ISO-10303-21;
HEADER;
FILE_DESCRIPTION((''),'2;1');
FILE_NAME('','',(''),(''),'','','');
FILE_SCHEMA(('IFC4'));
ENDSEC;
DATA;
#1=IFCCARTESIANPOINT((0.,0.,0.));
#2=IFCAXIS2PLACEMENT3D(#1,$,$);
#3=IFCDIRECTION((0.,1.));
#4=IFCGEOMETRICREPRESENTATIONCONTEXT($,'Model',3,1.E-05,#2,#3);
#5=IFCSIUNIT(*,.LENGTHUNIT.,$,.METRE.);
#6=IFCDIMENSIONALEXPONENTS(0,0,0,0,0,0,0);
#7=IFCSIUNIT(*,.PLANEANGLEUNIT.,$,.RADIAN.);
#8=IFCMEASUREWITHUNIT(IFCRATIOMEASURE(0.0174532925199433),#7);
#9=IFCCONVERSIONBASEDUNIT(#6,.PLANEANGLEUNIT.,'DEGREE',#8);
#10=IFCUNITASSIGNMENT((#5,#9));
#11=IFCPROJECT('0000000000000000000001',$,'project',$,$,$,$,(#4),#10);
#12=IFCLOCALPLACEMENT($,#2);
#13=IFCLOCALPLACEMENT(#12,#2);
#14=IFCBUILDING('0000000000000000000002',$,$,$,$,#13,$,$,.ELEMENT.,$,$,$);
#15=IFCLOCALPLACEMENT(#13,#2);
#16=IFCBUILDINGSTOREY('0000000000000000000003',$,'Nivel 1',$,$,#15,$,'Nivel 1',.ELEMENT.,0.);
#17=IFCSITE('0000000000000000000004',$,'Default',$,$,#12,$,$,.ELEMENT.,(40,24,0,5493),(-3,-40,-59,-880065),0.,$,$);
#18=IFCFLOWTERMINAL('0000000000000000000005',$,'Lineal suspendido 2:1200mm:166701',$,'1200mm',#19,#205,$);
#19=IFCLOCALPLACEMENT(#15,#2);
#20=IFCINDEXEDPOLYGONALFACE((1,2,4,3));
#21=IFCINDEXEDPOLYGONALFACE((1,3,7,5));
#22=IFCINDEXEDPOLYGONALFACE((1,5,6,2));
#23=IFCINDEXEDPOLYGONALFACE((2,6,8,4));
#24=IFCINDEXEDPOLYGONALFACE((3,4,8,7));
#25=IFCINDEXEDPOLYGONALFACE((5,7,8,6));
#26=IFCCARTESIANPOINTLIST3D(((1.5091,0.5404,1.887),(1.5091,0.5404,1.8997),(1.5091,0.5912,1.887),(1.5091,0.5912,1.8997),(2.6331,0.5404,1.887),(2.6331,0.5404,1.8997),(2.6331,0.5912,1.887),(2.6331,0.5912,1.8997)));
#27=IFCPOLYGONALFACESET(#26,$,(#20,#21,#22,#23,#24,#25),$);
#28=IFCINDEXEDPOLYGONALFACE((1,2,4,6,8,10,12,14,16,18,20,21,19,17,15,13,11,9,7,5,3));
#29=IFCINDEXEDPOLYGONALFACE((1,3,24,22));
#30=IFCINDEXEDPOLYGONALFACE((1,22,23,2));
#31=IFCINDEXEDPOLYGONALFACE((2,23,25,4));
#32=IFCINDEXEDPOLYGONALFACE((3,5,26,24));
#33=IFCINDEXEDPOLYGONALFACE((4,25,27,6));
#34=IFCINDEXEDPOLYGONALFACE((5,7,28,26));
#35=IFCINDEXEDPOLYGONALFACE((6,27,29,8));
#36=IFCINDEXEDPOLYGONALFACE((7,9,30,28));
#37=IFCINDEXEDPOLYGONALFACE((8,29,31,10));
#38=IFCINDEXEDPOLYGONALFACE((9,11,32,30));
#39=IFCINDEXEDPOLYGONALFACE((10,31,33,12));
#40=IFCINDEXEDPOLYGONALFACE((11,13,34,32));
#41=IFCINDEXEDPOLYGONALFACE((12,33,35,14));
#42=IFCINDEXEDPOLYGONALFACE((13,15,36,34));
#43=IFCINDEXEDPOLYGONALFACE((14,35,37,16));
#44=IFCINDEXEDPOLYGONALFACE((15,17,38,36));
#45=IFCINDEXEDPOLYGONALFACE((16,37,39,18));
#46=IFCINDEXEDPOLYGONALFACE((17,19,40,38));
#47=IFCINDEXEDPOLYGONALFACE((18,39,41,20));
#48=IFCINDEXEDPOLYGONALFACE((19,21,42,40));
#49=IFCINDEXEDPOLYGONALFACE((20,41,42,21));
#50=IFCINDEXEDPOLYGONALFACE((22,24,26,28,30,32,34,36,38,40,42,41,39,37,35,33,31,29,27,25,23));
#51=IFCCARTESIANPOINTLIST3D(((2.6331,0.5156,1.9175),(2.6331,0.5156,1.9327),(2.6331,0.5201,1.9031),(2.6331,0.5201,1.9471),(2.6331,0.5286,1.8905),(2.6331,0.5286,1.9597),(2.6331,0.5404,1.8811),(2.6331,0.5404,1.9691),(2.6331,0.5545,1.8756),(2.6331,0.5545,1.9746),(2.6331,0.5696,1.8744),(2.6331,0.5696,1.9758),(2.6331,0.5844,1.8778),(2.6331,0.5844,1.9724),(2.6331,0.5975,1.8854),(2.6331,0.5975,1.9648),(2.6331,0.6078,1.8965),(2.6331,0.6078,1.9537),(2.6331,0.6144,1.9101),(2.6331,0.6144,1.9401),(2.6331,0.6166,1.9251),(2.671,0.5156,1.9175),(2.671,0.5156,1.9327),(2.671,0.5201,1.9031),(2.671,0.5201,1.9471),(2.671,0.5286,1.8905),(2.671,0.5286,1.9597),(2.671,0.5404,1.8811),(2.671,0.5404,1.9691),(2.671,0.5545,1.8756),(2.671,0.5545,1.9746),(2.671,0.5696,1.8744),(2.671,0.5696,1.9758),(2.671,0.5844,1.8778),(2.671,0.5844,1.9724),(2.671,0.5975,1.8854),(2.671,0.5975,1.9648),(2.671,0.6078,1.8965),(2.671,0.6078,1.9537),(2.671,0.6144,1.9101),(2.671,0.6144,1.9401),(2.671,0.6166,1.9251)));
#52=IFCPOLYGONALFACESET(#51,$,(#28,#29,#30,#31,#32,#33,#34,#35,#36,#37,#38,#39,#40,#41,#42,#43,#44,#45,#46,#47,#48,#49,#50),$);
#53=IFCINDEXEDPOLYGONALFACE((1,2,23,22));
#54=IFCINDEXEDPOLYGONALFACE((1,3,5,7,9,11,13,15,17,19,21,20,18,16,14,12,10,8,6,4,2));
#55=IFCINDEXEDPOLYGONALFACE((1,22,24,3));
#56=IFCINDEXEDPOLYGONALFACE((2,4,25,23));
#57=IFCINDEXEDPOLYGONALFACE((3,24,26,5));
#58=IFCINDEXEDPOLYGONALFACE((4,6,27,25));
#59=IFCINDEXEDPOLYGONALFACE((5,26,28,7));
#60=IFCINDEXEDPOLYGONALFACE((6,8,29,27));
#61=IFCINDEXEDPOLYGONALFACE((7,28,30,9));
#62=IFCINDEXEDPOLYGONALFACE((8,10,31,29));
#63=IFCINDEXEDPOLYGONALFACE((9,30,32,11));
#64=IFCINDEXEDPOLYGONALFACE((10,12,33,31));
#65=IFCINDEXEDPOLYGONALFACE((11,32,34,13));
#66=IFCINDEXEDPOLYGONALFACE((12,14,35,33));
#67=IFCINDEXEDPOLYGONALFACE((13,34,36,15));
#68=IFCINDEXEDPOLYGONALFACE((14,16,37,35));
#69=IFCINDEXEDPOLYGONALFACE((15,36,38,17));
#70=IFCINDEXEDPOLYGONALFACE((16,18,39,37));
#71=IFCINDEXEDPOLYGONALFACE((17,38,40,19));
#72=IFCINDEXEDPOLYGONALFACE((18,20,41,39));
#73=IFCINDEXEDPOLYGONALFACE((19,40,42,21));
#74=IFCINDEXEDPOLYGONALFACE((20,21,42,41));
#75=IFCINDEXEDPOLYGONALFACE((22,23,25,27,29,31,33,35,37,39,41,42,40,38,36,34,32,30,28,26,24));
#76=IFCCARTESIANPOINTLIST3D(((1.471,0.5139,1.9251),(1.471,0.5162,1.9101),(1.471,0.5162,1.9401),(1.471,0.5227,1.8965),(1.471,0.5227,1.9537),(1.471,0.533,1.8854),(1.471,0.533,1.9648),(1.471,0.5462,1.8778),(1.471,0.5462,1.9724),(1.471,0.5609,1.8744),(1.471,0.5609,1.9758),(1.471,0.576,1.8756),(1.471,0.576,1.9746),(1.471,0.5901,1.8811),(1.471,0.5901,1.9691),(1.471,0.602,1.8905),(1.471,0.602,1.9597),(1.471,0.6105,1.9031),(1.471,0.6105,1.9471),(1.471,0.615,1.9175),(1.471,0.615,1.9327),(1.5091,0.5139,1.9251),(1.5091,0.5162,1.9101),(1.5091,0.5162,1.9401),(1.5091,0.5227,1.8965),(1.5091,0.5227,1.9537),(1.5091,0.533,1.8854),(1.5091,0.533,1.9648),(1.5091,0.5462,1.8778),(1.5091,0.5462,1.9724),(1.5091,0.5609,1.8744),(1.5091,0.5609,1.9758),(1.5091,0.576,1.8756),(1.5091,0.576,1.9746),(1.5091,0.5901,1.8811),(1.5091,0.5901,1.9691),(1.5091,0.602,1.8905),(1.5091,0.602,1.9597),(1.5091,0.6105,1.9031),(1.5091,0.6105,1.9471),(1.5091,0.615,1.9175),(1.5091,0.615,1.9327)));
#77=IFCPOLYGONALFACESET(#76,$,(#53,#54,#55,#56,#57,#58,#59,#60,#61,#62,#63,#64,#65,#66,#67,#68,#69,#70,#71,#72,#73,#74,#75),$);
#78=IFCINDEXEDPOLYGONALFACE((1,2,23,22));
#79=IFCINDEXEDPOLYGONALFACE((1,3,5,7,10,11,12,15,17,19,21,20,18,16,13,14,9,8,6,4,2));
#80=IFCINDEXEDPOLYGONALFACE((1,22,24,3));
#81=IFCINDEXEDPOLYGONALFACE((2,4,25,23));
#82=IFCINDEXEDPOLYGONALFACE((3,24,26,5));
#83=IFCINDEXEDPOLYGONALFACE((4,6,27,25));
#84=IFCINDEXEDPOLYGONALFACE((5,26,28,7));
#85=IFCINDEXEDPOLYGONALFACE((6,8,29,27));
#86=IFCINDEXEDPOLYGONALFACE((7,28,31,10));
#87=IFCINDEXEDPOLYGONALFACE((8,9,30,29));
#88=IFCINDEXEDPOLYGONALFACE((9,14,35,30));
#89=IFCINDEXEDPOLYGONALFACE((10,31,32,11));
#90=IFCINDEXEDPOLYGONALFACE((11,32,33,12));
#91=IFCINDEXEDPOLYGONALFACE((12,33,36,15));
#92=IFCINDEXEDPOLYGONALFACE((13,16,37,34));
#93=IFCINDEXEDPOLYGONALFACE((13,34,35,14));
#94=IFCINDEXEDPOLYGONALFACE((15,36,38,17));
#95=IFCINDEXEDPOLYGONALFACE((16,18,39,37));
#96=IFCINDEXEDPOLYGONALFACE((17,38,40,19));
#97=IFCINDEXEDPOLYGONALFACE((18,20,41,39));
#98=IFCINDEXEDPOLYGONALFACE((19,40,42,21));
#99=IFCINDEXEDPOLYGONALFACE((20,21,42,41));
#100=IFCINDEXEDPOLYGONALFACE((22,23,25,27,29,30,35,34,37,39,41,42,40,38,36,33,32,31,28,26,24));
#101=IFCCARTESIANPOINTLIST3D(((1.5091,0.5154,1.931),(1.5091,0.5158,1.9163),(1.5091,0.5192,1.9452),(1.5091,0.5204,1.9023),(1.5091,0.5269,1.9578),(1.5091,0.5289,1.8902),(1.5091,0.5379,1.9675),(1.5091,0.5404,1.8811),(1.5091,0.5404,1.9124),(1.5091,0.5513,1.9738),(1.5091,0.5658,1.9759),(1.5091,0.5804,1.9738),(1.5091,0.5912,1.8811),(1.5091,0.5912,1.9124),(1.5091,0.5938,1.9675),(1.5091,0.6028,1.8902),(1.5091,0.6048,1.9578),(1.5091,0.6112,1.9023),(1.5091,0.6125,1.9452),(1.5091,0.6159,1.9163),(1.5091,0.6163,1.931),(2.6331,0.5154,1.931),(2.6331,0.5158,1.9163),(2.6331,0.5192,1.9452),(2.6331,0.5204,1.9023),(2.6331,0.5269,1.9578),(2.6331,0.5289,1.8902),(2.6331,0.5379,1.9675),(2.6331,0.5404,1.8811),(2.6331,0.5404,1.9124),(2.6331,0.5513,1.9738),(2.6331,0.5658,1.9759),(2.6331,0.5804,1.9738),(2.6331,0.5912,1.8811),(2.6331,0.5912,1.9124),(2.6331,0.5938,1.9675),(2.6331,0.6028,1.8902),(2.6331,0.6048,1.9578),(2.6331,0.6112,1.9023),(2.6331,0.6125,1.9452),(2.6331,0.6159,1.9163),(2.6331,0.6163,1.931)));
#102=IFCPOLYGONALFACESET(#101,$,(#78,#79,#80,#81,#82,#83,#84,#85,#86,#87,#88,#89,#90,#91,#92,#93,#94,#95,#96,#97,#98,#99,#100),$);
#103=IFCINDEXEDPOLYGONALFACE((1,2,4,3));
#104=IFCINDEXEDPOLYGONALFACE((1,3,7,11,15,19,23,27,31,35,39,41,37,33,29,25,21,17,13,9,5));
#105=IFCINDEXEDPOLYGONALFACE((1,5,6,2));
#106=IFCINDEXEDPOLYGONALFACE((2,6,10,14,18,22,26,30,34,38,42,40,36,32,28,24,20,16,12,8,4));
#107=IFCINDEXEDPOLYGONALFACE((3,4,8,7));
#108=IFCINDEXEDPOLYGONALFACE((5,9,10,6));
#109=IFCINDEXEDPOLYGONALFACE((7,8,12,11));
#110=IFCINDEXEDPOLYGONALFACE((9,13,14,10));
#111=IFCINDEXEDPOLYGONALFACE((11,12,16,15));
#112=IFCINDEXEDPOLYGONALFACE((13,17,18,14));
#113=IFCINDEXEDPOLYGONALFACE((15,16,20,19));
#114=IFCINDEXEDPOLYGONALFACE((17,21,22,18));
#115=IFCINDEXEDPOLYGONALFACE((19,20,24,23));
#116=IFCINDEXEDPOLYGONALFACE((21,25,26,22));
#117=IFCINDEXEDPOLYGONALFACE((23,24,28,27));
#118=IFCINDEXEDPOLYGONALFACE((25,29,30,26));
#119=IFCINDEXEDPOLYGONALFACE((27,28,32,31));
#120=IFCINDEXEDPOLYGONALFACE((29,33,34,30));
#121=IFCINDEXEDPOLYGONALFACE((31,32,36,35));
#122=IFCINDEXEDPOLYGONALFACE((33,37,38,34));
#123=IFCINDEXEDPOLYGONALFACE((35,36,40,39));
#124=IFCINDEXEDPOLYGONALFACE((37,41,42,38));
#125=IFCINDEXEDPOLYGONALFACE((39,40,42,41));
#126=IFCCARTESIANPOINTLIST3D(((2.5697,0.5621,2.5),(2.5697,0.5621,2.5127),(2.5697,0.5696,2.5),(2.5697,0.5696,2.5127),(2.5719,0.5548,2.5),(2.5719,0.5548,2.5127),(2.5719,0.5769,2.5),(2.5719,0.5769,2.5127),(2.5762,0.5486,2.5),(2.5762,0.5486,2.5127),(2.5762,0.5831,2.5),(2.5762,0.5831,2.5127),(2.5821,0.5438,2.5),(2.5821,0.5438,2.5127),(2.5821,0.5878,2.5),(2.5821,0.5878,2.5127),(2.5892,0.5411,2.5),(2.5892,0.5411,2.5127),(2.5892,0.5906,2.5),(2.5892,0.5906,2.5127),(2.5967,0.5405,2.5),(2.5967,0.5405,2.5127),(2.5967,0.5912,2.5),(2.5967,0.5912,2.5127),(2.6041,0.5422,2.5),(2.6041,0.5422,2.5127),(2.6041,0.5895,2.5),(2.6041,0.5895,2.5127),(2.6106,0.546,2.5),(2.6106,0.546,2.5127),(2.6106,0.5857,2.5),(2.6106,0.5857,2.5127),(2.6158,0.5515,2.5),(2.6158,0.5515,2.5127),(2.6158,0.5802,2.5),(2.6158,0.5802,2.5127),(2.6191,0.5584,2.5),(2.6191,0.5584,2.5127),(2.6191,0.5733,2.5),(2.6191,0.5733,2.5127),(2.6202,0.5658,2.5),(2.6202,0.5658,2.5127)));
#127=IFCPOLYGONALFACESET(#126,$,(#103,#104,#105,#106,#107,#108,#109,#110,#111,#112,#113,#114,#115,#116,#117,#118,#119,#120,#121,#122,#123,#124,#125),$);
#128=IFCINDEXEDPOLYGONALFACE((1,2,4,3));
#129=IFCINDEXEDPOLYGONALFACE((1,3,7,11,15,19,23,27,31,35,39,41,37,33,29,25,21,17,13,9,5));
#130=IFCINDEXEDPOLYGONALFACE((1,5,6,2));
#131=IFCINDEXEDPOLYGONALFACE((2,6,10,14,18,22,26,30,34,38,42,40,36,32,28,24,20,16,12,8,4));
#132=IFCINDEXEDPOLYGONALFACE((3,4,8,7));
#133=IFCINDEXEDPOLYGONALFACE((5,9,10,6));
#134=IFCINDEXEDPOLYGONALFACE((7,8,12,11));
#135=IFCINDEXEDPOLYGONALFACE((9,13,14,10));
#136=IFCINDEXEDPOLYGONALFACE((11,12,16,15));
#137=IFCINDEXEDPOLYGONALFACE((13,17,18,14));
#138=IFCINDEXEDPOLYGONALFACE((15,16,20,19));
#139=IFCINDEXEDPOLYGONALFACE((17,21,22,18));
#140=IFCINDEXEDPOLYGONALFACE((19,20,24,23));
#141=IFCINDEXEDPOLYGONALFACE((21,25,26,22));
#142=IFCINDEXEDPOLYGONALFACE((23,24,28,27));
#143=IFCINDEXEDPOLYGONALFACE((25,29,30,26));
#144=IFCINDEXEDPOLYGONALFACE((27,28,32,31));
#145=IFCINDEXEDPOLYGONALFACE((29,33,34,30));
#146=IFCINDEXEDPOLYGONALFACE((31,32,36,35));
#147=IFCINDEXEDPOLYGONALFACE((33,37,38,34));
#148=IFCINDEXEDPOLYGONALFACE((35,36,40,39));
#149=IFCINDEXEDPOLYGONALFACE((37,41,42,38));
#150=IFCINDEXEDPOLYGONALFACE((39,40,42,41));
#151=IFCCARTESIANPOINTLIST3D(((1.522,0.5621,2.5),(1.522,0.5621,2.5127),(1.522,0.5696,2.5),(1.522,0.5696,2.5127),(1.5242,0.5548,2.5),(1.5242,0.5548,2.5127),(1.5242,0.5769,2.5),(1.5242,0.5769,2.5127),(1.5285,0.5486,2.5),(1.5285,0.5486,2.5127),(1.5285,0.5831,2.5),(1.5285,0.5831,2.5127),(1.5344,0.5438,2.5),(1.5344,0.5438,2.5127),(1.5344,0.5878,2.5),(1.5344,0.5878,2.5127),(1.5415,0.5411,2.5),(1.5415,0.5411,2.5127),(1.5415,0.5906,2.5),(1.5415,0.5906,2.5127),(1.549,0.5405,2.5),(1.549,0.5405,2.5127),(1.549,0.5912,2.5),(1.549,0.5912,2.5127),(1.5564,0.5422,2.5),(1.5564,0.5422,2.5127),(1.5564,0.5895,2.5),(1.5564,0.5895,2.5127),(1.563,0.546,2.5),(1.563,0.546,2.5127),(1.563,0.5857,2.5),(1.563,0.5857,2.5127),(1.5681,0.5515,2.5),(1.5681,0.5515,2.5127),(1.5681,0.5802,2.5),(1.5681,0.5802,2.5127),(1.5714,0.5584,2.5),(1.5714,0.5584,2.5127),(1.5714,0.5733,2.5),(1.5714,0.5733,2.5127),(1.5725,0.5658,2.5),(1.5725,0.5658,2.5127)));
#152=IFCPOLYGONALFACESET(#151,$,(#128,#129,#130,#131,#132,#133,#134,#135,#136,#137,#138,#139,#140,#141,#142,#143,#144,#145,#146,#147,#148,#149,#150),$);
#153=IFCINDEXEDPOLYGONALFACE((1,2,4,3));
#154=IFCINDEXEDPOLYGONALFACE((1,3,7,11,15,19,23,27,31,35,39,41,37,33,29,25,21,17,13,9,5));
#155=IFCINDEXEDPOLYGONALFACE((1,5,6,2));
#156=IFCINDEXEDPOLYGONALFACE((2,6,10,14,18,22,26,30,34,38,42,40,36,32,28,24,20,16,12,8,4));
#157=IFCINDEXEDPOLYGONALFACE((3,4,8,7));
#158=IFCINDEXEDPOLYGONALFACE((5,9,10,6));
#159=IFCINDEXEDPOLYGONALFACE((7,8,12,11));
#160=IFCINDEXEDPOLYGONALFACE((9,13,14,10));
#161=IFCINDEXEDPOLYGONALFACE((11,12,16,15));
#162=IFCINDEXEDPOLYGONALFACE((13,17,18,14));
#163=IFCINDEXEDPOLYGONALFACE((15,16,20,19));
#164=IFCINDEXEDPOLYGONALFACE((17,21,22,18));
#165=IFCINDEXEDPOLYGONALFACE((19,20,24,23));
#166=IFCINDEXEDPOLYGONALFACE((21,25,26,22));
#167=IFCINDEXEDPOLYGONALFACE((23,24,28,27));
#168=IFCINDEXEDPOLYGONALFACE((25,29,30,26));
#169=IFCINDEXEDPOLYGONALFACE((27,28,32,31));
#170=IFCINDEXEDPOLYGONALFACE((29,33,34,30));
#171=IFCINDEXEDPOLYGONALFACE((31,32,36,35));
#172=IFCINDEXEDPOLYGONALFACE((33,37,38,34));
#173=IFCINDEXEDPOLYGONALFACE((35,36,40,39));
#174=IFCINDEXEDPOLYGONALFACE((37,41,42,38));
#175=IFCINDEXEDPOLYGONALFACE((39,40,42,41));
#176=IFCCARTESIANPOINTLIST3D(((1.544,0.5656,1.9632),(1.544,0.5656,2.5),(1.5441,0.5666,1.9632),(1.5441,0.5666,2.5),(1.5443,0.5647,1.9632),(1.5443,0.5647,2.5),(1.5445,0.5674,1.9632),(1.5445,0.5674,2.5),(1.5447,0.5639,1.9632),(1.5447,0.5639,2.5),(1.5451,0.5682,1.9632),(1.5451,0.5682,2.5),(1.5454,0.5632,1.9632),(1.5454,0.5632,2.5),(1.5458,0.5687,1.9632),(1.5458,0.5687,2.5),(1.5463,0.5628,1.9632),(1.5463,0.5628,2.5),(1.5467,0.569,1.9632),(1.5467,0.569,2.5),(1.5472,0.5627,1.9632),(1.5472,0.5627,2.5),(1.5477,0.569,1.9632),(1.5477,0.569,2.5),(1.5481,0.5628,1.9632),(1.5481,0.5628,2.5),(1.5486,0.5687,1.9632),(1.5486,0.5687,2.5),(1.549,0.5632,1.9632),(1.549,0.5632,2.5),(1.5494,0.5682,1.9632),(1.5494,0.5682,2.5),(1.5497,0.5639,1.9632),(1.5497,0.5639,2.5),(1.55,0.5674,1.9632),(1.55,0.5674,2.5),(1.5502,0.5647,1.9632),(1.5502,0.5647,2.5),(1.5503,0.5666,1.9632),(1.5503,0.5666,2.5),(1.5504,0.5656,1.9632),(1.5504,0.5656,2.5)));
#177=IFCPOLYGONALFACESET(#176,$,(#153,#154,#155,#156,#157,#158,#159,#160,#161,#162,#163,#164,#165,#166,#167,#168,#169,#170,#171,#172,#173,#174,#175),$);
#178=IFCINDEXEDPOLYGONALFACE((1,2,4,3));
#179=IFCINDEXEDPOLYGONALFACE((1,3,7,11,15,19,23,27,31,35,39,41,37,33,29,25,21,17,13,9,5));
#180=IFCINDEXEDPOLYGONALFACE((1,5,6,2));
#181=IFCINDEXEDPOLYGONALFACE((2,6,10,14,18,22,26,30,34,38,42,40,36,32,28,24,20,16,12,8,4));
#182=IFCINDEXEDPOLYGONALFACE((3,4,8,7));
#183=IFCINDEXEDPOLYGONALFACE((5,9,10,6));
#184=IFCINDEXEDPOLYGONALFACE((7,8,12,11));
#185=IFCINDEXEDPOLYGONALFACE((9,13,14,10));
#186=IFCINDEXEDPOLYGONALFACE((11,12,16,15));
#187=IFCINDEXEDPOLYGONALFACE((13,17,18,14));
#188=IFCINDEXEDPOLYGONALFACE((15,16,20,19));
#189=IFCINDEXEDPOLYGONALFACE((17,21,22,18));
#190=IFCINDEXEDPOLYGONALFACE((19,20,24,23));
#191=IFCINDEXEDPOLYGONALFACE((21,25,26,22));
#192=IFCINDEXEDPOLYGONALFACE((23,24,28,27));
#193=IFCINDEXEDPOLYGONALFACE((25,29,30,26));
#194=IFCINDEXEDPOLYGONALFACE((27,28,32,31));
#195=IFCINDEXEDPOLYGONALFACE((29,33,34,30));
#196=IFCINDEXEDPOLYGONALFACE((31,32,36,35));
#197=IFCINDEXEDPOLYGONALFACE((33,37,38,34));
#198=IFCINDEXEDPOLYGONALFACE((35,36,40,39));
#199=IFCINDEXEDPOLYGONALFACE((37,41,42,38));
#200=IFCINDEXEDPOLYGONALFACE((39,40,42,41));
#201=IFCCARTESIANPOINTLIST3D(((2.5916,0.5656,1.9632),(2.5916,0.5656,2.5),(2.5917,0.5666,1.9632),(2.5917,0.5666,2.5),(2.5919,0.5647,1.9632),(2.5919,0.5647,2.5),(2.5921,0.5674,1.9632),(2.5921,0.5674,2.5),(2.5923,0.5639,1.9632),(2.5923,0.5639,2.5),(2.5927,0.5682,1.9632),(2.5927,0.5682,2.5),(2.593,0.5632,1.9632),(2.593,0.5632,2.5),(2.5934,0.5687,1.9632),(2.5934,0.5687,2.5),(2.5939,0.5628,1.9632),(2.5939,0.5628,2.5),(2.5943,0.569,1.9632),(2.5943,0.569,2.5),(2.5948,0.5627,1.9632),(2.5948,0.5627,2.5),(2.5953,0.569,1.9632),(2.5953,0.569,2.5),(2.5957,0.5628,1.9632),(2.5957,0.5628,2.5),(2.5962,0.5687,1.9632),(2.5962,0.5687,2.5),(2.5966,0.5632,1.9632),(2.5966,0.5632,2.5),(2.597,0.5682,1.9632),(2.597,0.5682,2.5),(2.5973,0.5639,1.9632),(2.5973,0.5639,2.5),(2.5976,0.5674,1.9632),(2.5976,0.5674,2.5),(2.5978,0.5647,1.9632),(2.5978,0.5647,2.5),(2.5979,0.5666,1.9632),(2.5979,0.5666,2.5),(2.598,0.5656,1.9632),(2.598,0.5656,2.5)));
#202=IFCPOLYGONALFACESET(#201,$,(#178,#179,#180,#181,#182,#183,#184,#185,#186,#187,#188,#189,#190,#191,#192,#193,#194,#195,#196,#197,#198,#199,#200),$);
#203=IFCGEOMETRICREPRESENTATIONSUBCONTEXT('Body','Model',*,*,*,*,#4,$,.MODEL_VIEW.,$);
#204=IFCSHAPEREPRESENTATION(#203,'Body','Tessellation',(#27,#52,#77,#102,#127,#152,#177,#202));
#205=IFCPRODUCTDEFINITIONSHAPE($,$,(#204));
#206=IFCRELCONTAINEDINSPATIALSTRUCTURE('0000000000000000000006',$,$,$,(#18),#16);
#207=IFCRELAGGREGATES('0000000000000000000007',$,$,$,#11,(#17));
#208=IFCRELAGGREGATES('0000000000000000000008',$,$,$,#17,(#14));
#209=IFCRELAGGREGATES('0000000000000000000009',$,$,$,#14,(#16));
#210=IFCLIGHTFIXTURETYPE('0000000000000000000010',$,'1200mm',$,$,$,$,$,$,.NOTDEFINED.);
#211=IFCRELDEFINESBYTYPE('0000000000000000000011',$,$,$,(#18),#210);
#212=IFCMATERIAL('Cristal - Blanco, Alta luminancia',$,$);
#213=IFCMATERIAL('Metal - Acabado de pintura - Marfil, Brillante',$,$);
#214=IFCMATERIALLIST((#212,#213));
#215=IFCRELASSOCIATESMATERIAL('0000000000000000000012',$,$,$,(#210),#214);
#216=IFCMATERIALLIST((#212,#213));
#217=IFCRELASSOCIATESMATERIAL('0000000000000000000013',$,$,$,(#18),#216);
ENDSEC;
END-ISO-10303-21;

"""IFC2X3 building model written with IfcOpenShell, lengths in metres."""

from ifc_helpers import new_model, entity, si_unit, converted_unit, direction, frame, frame_2d, origin, origin_2d_with_axis, place, context, subcontext, project, spatial, polyline, circle_curve, parameter, trimmed, segment, composite_curve, rectangle, circle, outline, extrude, source, transform, mapped, material, material_list, type_object, type_shapes, element, save


model = new_model("IFC2X3")

# Units and contexts
model_context = context("Model", 3, precision=1e-05, world=origin(), true_north=direction((0.0, 1.0)))
body_context = subcontext(model_context, "Body", "Model", "MODEL_VIEW")
ifc_project = project(units=[si_unit("LENGTHUNIT", "METRE"), converted_unit("PLANEANGLEUNIT", "DEGREE", entity("IfcRatioMeasure", 0.0174532925199433), si_unit("PLANEANGLEUNIT", "RADIAN"), dimensions=[0, 0, 0, 0, 0, 0, 0])], contexts=[model_context])

# Site, building, storey
site_placement = place(None, origin())
site = spatial("IfcSite", under=ifc_project, at=site_placement, Name="Default", CompositionType="ELEMENT", RefLatitude=(40, 24, 0, 5493), RefLongitude=(-3, -40, -59, -880065), RefElevation=0.0)
building_placement = place(site_placement, origin())
building = spatial("IfcBuilding", under=site, at=building_placement, CompositionType="ELEMENT")
storey_placement = place(building_placement, origin())
storey = spatial("IfcBuildingStorey", under=building, at=storey_placement, Name="Nivel 1", LongName="Nivel 1", CompositionType="ELEMENT", Elevation=0.0)

# Flow terminal
ifc_material_1 = material(Name="Cristal - Blanco, Alta luminancia")
ifc_material_2 = material(Name="Metal - Acabado de pintura - Marfil, Brillante")
ifc_material_list_1 = material_list([ifc_material_1, ifc_material_2])
light_fixture_type = type_object("IfcLightFixtureType", Name="1200mm", PredefinedType="NOTDEFINED", material=ifc_material_list_1)
shared_shape = source(origin(), body_context, "Body", "SweptSolid", [
    extrude(rectangle(XDim=1.124, YDim=0.0508, at=origin_2d_with_axis()), frame((0.0001, 0.0, 1.8127), z_axis=(0.0, 0.0, 1.0), x_axis=(-1.0, 0.0, 0.0)), (0.0, 0.0, 1.0), 0.0127),
    extrude(circle(Radius=0.0508, at=frame_2d((0.0, 0.0), x_axis=(1.0, 0.0))), frame((0.5621, 0.0, 1.8508), z_axis=(1.0, 0.0, 0.0), x_axis=(0.0, 1.0, 0.0)), (0.0, 0.0, 1.0), 0.0379),
    extrude(circle(Radius=0.0508, at=frame_2d((0.0, 0.0), x_axis=(1.0, 0.0))), frame((-0.6, -0.0011, 1.8508), z_axis=(1.0, 0.0, 0.0), x_axis=(0.0, -1.0, 0.0)), (0.0, 0.0, 1.0), 0.0381),
    extrude(outline(composite_curve([segment(trimmed(circle_curve(frame_2d((0.0125, 0.0), x_axis=(0.0, 1.0)), 0.0508), [parameter(120.0)], [parameter(270.0)], True, "PARAMETER"), True, "CONTINUOUS"), segment(trimmed(circle_curve(frame_2d((0.0125, 0.0), x_axis=(0.0, 1.0)), 0.0508), [parameter(270.0)], [parameter(60.0)], True, "PARAMETER"), True, "CONTINUOUS"), segment(polyline([(-0.0315, 0.0254), (-0.0002, 0.0254)]), True, "CONTINUOUS"), segment(polyline([(-0.0002, 0.0254), (-0.0002, -0.0254)]), True, "CONTINUOUS"), segment(polyline([(-0.0002, -0.0254), (-0.0315, -0.0254)]), True, "CONTINUOUS")], self_intersect=False)), frame((-0.5619, 0.0, 1.8383), z_axis=(-1.0, 0.0, 0.0), x_axis=(0.0, 0.0, 1.0)), (0.0, 0.0, -1.0), 1.124),
    extrude(circle(Radius=0.0254, at=frame_2d((0.0, 0.0), x_axis=(1.0, 0.0))), frame((0.5238, 0.0, 2.4257)), (0.0, 0.0, 1.0), 0.0127),
    extrude(circle(Radius=0.0254, at=frame_2d((0.0, 0.0), x_axis=(1.0, 0.0))), frame((-0.5239, 0.0, 2.4257)), (0.0, 0.0, 1.0), 0.0127),
    extrude(circle(Radius=0.0032, at=frame_2d((0.0, 0.0), x_axis=(1.0, 0.0))), frame((-0.5238, 0.0, 1.8889), z_axis=(0.0, 0.0, 1.0), x_axis=(0.0, -1.0, 0.0)), (0.0, 0.0, 1.0), 0.5368),
    extrude(circle(Radius=0.0032, at=frame_2d((0.0, 0.0), x_axis=(1.0, 0.0))), frame((0.5238, 0.0, 1.8889), z_axis=(0.0, 0.0, 1.0), x_axis=(0.0, -1.0, 0.0)), (0.0, 0.0, 1.0), 0.5368),
])
type_shapes(light_fixture_type, [shared_shape])
ifc_material_list_2 = material_list([ifc_material_1, ifc_material_2])
flow_terminal_1_placement = place(storey_placement, frame((2.071, 0.5658, 0.0743)))
element("IfcFlowTerminal", 1, at=flow_terminal_1_placement, inside=storey, type_object=light_fixture_type, material=ifc_material_list_2, Name="Lineal suspendido 2:1200mm:166701", ObjectType="1200mm", context=body_context, shape_type="MappedRepresentation", body=[
    mapped(shared_shape, transform((0.0, 0.0, 0.0), scale=1.0)),
])

save(model, "model.ifc")
